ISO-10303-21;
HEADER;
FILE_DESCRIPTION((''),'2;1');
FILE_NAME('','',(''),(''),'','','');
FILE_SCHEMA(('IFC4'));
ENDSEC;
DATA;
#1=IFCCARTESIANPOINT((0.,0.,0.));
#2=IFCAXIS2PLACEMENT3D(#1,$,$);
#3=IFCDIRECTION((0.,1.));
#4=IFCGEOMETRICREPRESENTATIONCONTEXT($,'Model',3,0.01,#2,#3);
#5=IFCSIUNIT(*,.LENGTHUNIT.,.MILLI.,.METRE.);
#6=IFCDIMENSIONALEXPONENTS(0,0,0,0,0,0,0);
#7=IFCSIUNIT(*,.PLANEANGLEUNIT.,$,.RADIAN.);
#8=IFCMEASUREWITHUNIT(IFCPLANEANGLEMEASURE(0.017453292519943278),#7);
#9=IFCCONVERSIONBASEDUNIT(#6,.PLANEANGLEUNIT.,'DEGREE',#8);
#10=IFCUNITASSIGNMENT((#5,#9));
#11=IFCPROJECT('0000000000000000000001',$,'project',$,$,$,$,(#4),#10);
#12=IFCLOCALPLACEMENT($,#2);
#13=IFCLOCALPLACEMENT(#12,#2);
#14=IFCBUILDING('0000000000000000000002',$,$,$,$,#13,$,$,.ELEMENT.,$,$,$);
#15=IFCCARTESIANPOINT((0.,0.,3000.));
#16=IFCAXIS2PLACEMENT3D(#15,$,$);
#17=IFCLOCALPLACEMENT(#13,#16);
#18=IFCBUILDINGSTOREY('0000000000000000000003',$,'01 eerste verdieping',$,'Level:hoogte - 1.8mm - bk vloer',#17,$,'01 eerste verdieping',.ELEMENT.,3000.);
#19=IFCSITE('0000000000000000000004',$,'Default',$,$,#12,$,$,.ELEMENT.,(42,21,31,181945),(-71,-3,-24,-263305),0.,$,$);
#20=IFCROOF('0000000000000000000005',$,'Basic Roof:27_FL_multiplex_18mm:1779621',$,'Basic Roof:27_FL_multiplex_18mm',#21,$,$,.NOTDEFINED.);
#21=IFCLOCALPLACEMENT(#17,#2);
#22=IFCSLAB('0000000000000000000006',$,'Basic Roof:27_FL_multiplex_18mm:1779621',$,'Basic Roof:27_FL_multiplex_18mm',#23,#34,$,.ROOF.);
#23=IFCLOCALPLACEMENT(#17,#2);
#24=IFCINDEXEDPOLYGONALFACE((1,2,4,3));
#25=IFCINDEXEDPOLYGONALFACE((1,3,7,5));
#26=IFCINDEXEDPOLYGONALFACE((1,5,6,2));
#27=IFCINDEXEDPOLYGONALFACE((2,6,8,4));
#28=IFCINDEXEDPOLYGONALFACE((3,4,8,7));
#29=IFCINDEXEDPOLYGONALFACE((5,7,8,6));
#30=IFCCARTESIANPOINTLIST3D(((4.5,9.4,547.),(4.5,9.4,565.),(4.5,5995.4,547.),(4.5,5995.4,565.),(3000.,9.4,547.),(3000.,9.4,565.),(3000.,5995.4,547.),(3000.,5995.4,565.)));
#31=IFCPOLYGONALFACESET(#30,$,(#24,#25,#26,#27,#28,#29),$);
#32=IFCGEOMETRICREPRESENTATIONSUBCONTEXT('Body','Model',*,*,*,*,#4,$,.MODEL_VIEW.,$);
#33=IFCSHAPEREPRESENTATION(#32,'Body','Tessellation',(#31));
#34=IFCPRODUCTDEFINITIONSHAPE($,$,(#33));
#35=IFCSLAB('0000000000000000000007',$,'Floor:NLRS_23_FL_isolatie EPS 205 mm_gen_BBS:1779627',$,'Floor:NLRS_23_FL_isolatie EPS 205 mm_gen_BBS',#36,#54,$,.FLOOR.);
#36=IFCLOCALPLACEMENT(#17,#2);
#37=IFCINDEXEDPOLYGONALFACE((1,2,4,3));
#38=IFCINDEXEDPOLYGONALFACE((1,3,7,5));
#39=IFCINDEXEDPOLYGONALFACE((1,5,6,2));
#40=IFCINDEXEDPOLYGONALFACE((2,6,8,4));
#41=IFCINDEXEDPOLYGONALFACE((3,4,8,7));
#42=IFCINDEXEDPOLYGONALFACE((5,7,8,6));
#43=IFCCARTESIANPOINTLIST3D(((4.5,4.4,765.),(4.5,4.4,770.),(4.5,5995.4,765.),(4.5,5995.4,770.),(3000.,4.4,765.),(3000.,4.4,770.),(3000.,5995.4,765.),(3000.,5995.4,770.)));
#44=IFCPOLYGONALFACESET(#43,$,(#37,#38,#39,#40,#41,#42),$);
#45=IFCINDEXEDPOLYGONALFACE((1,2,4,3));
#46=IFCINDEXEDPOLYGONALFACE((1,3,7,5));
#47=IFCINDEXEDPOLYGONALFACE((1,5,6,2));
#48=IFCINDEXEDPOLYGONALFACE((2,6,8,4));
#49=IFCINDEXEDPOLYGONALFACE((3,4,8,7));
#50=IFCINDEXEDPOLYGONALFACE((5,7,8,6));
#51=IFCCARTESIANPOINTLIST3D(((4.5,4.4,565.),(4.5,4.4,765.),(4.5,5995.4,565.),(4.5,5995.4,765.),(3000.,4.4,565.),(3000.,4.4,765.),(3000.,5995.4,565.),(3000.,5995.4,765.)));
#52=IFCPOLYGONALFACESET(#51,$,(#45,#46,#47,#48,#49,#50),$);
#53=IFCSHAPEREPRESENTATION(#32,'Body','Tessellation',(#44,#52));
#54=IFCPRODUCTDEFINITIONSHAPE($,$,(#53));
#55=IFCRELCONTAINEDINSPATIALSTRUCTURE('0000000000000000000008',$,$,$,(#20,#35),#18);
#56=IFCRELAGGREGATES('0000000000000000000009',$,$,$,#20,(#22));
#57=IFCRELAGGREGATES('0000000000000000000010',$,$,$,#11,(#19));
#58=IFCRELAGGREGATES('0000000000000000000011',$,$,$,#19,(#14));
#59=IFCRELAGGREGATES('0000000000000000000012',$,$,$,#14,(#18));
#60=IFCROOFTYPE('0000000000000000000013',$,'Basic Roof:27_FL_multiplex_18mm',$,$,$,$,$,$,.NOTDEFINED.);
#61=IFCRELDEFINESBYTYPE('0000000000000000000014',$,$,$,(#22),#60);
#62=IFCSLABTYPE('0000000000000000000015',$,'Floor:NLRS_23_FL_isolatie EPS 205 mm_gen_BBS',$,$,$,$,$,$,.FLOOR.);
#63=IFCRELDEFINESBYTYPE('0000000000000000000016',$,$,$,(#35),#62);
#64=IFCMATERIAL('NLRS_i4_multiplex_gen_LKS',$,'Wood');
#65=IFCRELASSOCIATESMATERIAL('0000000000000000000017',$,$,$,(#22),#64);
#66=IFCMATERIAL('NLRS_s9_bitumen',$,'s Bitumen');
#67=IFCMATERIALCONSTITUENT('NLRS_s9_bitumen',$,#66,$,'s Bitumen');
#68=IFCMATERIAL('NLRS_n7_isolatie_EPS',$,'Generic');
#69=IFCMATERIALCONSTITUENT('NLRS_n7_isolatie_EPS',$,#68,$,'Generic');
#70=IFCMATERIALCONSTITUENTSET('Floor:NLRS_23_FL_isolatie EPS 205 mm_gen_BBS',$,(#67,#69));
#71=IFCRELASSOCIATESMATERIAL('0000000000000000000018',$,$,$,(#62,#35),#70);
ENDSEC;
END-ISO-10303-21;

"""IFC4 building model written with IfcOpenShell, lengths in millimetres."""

from ifc_helpers import new_model, entity, si_unit, converted_unit, direction, frame, origin, place, context, subcontext, project, spatial, indexed_curve, outline, extrude, material, constituent, constituent_set, type_object, element, aggregate, save


model = new_model("IFC4")

# Units and contexts
model_context = context("Model", 3, precision=0.01, world=origin(), true_north=direction((0.0, 1.0)))
body_context = subcontext(model_context, "Body", "Model", "MODEL_VIEW")
ifc_project = project(units=[si_unit("LENGTHUNIT", "METRE", prefix="MILLI"), converted_unit("PLANEANGLEUNIT", "DEGREE", entity("IfcPlaneAngleMeasure", 0.017453292519943278), si_unit("PLANEANGLEUNIT", "RADIAN"), dimensions=[0, 0, 0, 0, 0, 0, 0])], contexts=[model_context])

# Site, building, storey
site_placement = place(None, origin())
site = spatial("IfcSite", under=ifc_project, at=site_placement, Name="Default", CompositionType="ELEMENT", RefLatitude=(42, 21, 31, 181945), RefLongitude=(-71, -3, -24, -263305), RefElevation=0.0)
building_placement = place(site_placement, origin())
building = spatial("IfcBuilding", under=site, at=building_placement, CompositionType="ELEMENT")
storey_placement = place(building_placement, frame((0.0, 0.0, 3000.0)))
storey = spatial("IfcBuildingStorey", under=building, at=storey_placement, Name="01 eerste verdieping", ObjectType="Level:hoogte - 1.8mm - bk vloer", LongName="01 eerste verdieping", CompositionType="ELEMENT", Elevation=3000.0)

# Roof, slab
roof_placement = place(storey_placement, frame((4.5, 9.4, 547.0)))
roof = element("IfcRoof", 1, at=roof_placement, inside=storey, Name="Basic Roof:27_FL_multiplex_18mm:1779621", ObjectType="Basic Roof:27_FL_multiplex_18mm", PredefinedType="NOTDEFINED")
ifc_material_1 = material(Name="NLRS_i4_multiplex_gen_LKS", Category="Wood")
roof_type = type_object("IfcRoofType", Name="Basic Roof:27_FL_multiplex_18mm", PredefinedType="NOTDEFINED")
slab_1_placement = place(roof_placement, origin())
slab_1 = element("IfcSlab", 2, at=slab_1_placement, type_object=roof_type, material=ifc_material_1, Name="Basic Roof:27_FL_multiplex_18mm:1779621", ObjectType="Basic Roof:27_FL_multiplex_18mm", PredefinedType="ROOF", context=body_context, shape_type="SweptSolid", body=[
    extrude(outline(indexed_curve([(-1497.8, 2993.0), (-1497.8, -2993.0), (1497.8, -2993.0), (1497.8, 2993.0), (-1497.8, 2993.0)], self_intersect=False)), frame((1497.8, 2993.0, 0.0)), (0.0, 0.0, 1.0), 18.0),
])
aggregate(roof, [slab_1])

# Slab
ifc_material_2 = material(Name="NLRS_s9_bitumen", Category="s Bitumen")
ifc_constituent_1 = constituent(ifc_material_2, Name="NLRS_s9_bitumen", Category="s Bitumen")
ifc_material_3 = material(Name="NLRS_n7_isolatie_EPS", Category="Generic")
ifc_constituent_2 = constituent(ifc_material_3, Name="NLRS_n7_isolatie_EPS", Category="Generic")
ifc_constituent_set = constituent_set(constituents=[ifc_constituent_1, ifc_constituent_2], Name="Floor:NLRS_23_FL_isolatie EPS 205 mm_gen_BBS")
slab_type = type_object("IfcSlabType", Name="Floor:NLRS_23_FL_isolatie EPS 205 mm_gen_BBS", PredefinedType="FLOOR", material=ifc_constituent_set)
slab_2_placement = place(storey_placement, origin())
element("IfcSlab", 3, at=slab_2_placement, inside=storey, type_object=slab_type, material=ifc_constituent_set, Name="Floor:NLRS_23_FL_isolatie EPS 205 mm_gen_BBS:1779627", ObjectType="Floor:NLRS_23_FL_isolatie EPS 205 mm_gen_BBS", PredefinedType="FLOOR", context=body_context, shape_type="SweptSolid", body=[
    extrude(outline(indexed_curve([(-2995.5, -1497.8), (2995.5, -1497.8), (2995.5, 1497.8), (-2995.5, 1497.8), (-2995.5, -1497.8)], self_intersect=False)), frame((1502.2, 2999.9, 765.0), z_axis=(0.0, 0.0, 1.0), x_axis=(0.0, 1.0, 0.0)), (0.0, 0.0, 1.0), 5.0),
    extrude(outline(indexed_curve([(-2995.5, -1497.8), (2995.5, -1497.8), (2995.5, 1497.8), (-2995.5, 1497.8), (-2995.5, -1497.8)], self_intersect=False)), frame((1502.2, 2999.9, 565.0), z_axis=(0.0, 0.0, 1.0), x_axis=(0.0, 1.0, 0.0)), (0.0, 0.0, 1.0), 200.0),
])

save(model, "model.ifc")
